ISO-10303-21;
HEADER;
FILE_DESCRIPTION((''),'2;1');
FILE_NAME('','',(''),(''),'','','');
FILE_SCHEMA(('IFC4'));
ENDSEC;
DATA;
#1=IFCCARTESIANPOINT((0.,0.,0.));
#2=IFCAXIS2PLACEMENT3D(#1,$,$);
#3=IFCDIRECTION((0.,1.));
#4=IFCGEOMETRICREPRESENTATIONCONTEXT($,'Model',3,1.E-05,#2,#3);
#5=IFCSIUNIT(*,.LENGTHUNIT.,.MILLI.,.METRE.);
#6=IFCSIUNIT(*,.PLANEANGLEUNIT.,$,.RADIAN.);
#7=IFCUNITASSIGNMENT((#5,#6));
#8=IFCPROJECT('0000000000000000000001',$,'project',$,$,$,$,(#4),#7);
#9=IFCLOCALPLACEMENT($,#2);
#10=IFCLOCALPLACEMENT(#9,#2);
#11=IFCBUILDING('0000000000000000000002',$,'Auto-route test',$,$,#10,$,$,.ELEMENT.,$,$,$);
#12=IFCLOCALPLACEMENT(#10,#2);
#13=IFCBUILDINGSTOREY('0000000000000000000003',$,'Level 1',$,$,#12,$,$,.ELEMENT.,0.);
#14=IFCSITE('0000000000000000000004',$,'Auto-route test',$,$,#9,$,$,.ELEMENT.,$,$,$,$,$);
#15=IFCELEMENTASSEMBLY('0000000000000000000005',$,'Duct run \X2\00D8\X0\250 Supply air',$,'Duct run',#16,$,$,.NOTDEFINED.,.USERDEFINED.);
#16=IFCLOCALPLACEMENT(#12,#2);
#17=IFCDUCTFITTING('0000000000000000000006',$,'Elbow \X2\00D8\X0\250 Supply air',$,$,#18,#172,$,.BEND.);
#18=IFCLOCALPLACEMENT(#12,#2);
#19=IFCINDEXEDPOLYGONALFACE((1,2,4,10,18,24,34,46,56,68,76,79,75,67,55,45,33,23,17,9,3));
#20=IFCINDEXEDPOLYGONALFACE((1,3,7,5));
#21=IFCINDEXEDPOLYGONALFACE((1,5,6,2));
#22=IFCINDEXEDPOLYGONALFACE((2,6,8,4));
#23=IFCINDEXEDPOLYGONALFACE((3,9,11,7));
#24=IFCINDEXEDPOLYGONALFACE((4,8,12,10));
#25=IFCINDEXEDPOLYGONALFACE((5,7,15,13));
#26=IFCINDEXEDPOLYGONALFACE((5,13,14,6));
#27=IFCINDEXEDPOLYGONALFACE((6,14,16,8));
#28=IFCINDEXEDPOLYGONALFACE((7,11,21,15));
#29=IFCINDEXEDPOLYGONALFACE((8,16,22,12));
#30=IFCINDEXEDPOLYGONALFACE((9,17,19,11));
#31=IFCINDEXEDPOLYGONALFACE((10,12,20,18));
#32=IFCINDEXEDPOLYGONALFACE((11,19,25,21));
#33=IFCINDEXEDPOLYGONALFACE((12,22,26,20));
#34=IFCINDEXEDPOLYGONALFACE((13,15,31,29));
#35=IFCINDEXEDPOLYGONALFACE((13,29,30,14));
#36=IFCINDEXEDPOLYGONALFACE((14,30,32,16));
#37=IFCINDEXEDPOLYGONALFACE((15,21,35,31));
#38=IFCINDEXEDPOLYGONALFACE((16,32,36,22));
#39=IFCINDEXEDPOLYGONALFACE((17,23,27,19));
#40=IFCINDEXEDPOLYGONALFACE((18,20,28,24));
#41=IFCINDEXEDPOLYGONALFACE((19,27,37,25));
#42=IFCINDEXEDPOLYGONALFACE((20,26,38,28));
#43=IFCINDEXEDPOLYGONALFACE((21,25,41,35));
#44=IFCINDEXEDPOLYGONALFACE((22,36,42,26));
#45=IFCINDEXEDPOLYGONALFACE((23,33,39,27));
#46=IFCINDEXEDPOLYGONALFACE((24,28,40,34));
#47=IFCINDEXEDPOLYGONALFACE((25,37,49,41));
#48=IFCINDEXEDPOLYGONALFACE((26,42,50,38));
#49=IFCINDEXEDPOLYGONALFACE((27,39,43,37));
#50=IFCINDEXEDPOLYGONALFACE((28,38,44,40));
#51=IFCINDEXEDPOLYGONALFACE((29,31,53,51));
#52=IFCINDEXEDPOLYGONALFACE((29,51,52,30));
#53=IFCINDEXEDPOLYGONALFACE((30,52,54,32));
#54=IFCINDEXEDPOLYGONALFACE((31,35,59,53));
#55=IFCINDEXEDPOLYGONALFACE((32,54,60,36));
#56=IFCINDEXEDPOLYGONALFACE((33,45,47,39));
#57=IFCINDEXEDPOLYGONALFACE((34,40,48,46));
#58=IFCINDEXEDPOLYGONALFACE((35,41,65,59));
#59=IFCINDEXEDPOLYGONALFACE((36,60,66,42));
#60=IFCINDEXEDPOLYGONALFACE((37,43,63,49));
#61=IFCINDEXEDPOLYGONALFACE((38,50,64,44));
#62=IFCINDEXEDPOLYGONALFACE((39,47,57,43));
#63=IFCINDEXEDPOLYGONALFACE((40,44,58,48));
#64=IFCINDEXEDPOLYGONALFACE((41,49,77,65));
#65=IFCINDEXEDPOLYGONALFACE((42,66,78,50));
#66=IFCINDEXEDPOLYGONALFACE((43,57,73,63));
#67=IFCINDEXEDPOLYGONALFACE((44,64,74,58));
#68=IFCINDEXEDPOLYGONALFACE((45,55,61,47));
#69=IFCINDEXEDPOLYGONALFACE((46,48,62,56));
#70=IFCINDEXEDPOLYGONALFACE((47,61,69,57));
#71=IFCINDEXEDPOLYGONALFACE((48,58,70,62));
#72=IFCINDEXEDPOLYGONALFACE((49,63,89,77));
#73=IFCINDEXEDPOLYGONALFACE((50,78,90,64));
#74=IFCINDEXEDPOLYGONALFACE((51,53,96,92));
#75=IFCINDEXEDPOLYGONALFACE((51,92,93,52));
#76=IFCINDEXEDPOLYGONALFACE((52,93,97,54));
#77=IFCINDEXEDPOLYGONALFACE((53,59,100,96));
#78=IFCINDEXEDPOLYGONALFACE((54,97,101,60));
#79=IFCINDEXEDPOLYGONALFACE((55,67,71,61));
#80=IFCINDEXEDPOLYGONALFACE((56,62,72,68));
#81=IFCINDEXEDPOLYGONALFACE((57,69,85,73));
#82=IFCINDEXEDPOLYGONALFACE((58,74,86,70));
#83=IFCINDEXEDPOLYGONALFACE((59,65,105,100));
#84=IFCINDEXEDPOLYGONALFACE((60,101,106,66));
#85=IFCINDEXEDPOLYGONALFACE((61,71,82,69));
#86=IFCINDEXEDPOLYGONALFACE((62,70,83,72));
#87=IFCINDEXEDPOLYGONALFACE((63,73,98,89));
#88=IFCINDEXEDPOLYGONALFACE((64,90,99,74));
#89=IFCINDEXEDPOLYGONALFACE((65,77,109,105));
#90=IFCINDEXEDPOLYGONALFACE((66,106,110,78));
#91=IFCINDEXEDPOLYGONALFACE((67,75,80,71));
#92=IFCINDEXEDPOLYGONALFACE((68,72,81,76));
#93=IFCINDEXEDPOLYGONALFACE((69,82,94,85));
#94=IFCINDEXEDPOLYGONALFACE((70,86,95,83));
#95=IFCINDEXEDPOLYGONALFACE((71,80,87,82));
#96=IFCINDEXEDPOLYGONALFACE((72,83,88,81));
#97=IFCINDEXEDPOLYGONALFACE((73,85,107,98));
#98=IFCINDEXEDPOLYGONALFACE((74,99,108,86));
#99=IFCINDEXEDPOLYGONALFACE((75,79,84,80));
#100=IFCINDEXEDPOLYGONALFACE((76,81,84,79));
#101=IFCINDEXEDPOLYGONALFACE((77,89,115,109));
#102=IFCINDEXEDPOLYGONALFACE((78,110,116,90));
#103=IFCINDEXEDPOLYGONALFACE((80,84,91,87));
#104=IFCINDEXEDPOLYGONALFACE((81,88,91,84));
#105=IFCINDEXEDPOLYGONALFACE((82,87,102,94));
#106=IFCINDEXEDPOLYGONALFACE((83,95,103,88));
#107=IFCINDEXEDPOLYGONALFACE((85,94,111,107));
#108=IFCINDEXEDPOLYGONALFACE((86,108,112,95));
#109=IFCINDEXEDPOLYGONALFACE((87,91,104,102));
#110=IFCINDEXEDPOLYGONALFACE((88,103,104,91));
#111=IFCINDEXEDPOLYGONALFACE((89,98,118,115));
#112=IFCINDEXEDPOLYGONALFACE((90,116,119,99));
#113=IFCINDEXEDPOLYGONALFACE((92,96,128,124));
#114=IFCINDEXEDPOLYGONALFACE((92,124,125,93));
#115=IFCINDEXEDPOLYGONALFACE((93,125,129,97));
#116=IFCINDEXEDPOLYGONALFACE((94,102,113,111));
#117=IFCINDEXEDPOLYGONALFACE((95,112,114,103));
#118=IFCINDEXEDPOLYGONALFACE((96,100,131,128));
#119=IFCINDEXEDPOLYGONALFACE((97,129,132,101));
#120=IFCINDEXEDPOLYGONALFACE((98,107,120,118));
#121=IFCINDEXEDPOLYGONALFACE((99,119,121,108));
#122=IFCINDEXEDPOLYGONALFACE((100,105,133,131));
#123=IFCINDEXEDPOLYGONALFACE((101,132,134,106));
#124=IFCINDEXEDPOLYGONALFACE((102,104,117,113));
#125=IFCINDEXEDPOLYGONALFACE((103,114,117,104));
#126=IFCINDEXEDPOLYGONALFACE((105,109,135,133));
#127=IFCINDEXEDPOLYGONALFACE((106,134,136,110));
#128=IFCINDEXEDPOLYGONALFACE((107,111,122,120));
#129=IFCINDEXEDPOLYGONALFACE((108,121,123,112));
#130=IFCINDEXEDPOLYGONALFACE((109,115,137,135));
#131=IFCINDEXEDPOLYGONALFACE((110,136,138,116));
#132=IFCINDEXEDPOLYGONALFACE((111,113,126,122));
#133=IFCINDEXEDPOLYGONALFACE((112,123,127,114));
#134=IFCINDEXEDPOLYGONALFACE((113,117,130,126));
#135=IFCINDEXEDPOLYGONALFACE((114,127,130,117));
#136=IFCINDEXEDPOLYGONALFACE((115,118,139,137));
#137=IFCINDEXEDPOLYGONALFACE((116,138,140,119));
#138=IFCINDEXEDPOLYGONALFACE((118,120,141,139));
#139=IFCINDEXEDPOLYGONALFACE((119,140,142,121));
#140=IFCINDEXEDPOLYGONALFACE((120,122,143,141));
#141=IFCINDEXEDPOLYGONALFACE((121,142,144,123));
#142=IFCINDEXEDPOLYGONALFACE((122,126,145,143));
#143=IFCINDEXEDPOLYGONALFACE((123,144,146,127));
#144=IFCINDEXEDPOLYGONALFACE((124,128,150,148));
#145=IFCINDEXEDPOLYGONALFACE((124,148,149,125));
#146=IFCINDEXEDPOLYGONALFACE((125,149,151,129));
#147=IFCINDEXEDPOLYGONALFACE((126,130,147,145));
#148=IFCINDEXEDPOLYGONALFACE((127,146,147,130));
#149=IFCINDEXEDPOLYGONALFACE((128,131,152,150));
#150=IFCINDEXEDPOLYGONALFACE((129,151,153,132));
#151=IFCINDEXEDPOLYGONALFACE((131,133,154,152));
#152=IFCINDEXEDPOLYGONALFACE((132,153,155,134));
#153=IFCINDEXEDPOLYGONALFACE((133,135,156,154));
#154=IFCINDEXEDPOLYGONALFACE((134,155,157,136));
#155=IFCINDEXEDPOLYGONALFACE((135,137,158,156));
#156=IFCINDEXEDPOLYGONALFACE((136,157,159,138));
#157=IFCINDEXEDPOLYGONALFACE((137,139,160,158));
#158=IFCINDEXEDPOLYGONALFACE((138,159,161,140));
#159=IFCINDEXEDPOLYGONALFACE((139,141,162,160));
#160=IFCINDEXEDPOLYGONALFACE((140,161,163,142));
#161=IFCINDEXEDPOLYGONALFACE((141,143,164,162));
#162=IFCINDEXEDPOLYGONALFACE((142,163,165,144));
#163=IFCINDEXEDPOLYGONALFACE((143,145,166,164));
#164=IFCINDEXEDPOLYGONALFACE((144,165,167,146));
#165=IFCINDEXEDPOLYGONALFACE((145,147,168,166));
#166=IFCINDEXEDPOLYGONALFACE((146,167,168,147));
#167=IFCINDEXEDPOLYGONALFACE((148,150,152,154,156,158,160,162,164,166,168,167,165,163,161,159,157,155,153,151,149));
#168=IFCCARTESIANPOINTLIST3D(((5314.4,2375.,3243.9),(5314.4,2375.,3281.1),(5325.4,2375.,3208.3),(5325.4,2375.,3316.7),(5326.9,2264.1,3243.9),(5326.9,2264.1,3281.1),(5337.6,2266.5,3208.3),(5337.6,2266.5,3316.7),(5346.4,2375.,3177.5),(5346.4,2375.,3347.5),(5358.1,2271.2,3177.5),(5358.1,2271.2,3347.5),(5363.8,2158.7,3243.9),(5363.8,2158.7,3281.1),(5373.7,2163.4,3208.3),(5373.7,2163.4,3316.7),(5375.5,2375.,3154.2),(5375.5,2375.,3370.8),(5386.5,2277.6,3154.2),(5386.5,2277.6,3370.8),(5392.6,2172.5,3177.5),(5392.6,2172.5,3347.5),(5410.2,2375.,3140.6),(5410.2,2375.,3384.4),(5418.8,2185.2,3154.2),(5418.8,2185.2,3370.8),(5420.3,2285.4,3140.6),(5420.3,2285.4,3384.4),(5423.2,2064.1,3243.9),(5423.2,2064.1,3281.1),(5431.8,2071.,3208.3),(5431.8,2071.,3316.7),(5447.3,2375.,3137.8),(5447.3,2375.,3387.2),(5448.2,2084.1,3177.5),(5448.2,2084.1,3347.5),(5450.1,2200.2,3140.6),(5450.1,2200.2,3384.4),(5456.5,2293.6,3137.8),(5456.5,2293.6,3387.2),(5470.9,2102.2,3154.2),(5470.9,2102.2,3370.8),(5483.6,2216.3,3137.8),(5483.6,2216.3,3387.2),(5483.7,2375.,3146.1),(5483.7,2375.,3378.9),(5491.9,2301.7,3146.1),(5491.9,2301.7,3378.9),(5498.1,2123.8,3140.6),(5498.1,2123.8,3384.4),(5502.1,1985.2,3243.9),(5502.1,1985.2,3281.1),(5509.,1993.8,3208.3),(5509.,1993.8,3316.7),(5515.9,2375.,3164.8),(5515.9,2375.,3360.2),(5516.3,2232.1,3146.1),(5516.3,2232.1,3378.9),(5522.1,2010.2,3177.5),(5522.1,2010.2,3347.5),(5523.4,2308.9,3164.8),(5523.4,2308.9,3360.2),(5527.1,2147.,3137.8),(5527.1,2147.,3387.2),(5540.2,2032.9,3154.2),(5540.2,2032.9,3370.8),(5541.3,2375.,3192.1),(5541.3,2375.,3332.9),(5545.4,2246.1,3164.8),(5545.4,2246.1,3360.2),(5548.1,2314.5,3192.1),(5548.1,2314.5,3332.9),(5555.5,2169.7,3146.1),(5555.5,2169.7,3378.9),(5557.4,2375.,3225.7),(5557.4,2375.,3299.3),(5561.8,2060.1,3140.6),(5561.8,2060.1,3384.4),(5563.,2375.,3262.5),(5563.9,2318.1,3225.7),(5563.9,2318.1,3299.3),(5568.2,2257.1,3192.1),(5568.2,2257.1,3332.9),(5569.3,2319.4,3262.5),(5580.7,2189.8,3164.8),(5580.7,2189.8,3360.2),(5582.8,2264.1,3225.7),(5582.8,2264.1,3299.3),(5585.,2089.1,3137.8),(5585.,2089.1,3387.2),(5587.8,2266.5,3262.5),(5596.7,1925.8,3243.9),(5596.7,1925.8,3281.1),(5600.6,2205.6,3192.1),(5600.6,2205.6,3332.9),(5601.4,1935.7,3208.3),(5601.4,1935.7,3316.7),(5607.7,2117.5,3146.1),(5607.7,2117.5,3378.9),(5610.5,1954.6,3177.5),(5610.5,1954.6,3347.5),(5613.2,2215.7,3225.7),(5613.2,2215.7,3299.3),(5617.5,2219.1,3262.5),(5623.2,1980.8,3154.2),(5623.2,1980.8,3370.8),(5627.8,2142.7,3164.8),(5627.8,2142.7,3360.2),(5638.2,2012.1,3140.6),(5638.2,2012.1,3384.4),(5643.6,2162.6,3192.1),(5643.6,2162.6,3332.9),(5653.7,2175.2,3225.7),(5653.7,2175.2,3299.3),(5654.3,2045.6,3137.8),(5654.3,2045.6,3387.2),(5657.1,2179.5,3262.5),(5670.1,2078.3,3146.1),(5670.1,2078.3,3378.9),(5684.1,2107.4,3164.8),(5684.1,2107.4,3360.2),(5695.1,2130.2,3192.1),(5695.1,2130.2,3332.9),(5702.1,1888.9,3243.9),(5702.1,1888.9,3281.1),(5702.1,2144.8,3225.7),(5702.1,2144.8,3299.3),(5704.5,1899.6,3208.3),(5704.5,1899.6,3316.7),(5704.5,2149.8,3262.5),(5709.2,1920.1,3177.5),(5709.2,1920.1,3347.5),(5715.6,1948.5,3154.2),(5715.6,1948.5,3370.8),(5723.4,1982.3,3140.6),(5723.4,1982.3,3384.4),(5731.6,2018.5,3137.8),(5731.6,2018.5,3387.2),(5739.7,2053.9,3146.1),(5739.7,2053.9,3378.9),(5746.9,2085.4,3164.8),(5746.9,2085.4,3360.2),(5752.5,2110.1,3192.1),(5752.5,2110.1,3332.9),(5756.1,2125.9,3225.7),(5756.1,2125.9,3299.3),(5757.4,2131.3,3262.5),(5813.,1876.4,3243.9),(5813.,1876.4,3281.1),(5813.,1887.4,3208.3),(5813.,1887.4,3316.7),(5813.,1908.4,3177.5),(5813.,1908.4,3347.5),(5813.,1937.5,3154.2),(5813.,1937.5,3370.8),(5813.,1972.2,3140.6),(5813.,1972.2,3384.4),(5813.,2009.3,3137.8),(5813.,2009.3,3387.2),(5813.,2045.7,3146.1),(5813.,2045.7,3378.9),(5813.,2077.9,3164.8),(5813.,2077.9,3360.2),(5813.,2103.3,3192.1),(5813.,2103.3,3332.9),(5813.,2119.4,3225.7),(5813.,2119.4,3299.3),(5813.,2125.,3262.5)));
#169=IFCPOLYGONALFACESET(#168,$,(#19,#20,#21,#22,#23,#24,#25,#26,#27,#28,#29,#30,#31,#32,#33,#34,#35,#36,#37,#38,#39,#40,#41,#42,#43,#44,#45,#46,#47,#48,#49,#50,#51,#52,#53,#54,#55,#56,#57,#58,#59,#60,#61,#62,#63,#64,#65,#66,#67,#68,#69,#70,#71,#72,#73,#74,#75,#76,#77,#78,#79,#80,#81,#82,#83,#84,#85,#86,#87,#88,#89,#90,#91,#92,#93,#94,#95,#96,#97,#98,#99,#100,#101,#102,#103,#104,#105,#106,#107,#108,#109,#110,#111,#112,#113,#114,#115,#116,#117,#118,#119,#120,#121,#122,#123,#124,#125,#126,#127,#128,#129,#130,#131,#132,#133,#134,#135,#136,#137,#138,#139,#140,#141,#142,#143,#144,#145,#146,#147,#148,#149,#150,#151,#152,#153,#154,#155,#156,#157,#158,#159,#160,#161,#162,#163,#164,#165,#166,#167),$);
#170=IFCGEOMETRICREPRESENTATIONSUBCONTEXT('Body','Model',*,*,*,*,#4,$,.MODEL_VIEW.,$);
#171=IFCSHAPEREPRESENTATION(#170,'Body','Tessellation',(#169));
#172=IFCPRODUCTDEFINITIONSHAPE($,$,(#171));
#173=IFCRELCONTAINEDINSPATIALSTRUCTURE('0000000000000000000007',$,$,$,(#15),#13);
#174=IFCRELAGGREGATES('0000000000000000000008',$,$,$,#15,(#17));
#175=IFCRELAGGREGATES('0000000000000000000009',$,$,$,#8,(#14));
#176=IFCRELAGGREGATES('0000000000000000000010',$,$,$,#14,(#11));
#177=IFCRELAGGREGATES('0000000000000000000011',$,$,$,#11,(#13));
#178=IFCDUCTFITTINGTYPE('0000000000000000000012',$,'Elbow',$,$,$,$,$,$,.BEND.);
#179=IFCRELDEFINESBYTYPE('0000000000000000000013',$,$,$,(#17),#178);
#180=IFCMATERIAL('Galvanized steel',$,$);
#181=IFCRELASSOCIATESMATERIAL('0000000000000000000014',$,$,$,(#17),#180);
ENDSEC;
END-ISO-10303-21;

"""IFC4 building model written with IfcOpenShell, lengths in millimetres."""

from ifc_helpers import new_model, entity, si_unit, direction, origin, origin_with_axes, place, context, subcontext, project, spatial, material, type_object, element, aggregate, save


model = new_model("IFC4")

# Units and contexts
model_context = context("Model", 3, precision=1e-05, world=origin(), true_north=direction((0.0, 1.0)))
body_context = subcontext(model_context, "Body", "Model", "MODEL_VIEW")
ifc_project = project(units=[si_unit("LENGTHUNIT", "METRE", prefix="MILLI"), si_unit("PLANEANGLEUNIT", "RADIAN")], contexts=[model_context])

# Site, building, storey
site_placement = place(None, origin())
site = spatial("IfcSite", under=ifc_project, at=site_placement, Name="Auto-route test", CompositionType="ELEMENT")
building_placement = place(site_placement, origin())
building = spatial("IfcBuilding", under=site, at=building_placement, Name="Auto-route test", CompositionType="ELEMENT")
storey_placement = place(building_placement, origin())
storey = spatial("IfcBuildingStorey", under=building, at=storey_placement, Name="Level 1", CompositionType="ELEMENT", Elevation=0.0)

# Shared definitions
ifc_material_1 = material(Name="Galvanized steel")

# Shared definitions
duct_fitting_type_1 = type_object("IfcDuctFittingType", Name="Elbow", PredefinedType="BEND")

# Element assembly, duct fitting
assembly_1_placement = place(storey_placement, origin_with_axes())
assembly_1 = element("IfcElementAssembly", 1, at=assembly_1_placement, inside=storey, Name="Duct run Ø250 Supply air", ObjectType="Duct run", AssemblyPlace="NOTDEFINED", PredefinedType="USERDEFINED")
duct_fitting_1_placement = place(storey_placement, origin_with_axes())
duct_fitting_1 = element("IfcDuctFitting", 2, at=duct_fitting_1_placement, type_object=duct_fitting_type_1, material=ifc_material_1, Name="Elbow Ø250 Supply air", PredefinedType="BEND", context=body_context, shape_type="SweptSolid", body=[
    entity("IfcRevolvedAreaSolid", entity("IfcCircleProfileDef", "AREA", None, entity("IfcAxis2Placement2D", entity("IfcCartesianPoint", [0.0, 0.0])), 125.0), entity("IfcAxis2Placement3D", entity("IfcCartesianPoint", [5438.0, 2375.0, 3262.5]), entity("IfcDirection", [0.0, -1.0, 0.0]), entity("IfcDirection", [1.0, 0.0, 0.0])), entity("IfcAxis1Placement", entity("IfcCartesianPoint", [375.0, 0.0, 0.0]), entity("IfcDirection", [0.0, 1.0, 0.0])), 1.570796),
])

aggregate(assembly_1, [duct_fitting_1])

save(model, "model.ifc")
